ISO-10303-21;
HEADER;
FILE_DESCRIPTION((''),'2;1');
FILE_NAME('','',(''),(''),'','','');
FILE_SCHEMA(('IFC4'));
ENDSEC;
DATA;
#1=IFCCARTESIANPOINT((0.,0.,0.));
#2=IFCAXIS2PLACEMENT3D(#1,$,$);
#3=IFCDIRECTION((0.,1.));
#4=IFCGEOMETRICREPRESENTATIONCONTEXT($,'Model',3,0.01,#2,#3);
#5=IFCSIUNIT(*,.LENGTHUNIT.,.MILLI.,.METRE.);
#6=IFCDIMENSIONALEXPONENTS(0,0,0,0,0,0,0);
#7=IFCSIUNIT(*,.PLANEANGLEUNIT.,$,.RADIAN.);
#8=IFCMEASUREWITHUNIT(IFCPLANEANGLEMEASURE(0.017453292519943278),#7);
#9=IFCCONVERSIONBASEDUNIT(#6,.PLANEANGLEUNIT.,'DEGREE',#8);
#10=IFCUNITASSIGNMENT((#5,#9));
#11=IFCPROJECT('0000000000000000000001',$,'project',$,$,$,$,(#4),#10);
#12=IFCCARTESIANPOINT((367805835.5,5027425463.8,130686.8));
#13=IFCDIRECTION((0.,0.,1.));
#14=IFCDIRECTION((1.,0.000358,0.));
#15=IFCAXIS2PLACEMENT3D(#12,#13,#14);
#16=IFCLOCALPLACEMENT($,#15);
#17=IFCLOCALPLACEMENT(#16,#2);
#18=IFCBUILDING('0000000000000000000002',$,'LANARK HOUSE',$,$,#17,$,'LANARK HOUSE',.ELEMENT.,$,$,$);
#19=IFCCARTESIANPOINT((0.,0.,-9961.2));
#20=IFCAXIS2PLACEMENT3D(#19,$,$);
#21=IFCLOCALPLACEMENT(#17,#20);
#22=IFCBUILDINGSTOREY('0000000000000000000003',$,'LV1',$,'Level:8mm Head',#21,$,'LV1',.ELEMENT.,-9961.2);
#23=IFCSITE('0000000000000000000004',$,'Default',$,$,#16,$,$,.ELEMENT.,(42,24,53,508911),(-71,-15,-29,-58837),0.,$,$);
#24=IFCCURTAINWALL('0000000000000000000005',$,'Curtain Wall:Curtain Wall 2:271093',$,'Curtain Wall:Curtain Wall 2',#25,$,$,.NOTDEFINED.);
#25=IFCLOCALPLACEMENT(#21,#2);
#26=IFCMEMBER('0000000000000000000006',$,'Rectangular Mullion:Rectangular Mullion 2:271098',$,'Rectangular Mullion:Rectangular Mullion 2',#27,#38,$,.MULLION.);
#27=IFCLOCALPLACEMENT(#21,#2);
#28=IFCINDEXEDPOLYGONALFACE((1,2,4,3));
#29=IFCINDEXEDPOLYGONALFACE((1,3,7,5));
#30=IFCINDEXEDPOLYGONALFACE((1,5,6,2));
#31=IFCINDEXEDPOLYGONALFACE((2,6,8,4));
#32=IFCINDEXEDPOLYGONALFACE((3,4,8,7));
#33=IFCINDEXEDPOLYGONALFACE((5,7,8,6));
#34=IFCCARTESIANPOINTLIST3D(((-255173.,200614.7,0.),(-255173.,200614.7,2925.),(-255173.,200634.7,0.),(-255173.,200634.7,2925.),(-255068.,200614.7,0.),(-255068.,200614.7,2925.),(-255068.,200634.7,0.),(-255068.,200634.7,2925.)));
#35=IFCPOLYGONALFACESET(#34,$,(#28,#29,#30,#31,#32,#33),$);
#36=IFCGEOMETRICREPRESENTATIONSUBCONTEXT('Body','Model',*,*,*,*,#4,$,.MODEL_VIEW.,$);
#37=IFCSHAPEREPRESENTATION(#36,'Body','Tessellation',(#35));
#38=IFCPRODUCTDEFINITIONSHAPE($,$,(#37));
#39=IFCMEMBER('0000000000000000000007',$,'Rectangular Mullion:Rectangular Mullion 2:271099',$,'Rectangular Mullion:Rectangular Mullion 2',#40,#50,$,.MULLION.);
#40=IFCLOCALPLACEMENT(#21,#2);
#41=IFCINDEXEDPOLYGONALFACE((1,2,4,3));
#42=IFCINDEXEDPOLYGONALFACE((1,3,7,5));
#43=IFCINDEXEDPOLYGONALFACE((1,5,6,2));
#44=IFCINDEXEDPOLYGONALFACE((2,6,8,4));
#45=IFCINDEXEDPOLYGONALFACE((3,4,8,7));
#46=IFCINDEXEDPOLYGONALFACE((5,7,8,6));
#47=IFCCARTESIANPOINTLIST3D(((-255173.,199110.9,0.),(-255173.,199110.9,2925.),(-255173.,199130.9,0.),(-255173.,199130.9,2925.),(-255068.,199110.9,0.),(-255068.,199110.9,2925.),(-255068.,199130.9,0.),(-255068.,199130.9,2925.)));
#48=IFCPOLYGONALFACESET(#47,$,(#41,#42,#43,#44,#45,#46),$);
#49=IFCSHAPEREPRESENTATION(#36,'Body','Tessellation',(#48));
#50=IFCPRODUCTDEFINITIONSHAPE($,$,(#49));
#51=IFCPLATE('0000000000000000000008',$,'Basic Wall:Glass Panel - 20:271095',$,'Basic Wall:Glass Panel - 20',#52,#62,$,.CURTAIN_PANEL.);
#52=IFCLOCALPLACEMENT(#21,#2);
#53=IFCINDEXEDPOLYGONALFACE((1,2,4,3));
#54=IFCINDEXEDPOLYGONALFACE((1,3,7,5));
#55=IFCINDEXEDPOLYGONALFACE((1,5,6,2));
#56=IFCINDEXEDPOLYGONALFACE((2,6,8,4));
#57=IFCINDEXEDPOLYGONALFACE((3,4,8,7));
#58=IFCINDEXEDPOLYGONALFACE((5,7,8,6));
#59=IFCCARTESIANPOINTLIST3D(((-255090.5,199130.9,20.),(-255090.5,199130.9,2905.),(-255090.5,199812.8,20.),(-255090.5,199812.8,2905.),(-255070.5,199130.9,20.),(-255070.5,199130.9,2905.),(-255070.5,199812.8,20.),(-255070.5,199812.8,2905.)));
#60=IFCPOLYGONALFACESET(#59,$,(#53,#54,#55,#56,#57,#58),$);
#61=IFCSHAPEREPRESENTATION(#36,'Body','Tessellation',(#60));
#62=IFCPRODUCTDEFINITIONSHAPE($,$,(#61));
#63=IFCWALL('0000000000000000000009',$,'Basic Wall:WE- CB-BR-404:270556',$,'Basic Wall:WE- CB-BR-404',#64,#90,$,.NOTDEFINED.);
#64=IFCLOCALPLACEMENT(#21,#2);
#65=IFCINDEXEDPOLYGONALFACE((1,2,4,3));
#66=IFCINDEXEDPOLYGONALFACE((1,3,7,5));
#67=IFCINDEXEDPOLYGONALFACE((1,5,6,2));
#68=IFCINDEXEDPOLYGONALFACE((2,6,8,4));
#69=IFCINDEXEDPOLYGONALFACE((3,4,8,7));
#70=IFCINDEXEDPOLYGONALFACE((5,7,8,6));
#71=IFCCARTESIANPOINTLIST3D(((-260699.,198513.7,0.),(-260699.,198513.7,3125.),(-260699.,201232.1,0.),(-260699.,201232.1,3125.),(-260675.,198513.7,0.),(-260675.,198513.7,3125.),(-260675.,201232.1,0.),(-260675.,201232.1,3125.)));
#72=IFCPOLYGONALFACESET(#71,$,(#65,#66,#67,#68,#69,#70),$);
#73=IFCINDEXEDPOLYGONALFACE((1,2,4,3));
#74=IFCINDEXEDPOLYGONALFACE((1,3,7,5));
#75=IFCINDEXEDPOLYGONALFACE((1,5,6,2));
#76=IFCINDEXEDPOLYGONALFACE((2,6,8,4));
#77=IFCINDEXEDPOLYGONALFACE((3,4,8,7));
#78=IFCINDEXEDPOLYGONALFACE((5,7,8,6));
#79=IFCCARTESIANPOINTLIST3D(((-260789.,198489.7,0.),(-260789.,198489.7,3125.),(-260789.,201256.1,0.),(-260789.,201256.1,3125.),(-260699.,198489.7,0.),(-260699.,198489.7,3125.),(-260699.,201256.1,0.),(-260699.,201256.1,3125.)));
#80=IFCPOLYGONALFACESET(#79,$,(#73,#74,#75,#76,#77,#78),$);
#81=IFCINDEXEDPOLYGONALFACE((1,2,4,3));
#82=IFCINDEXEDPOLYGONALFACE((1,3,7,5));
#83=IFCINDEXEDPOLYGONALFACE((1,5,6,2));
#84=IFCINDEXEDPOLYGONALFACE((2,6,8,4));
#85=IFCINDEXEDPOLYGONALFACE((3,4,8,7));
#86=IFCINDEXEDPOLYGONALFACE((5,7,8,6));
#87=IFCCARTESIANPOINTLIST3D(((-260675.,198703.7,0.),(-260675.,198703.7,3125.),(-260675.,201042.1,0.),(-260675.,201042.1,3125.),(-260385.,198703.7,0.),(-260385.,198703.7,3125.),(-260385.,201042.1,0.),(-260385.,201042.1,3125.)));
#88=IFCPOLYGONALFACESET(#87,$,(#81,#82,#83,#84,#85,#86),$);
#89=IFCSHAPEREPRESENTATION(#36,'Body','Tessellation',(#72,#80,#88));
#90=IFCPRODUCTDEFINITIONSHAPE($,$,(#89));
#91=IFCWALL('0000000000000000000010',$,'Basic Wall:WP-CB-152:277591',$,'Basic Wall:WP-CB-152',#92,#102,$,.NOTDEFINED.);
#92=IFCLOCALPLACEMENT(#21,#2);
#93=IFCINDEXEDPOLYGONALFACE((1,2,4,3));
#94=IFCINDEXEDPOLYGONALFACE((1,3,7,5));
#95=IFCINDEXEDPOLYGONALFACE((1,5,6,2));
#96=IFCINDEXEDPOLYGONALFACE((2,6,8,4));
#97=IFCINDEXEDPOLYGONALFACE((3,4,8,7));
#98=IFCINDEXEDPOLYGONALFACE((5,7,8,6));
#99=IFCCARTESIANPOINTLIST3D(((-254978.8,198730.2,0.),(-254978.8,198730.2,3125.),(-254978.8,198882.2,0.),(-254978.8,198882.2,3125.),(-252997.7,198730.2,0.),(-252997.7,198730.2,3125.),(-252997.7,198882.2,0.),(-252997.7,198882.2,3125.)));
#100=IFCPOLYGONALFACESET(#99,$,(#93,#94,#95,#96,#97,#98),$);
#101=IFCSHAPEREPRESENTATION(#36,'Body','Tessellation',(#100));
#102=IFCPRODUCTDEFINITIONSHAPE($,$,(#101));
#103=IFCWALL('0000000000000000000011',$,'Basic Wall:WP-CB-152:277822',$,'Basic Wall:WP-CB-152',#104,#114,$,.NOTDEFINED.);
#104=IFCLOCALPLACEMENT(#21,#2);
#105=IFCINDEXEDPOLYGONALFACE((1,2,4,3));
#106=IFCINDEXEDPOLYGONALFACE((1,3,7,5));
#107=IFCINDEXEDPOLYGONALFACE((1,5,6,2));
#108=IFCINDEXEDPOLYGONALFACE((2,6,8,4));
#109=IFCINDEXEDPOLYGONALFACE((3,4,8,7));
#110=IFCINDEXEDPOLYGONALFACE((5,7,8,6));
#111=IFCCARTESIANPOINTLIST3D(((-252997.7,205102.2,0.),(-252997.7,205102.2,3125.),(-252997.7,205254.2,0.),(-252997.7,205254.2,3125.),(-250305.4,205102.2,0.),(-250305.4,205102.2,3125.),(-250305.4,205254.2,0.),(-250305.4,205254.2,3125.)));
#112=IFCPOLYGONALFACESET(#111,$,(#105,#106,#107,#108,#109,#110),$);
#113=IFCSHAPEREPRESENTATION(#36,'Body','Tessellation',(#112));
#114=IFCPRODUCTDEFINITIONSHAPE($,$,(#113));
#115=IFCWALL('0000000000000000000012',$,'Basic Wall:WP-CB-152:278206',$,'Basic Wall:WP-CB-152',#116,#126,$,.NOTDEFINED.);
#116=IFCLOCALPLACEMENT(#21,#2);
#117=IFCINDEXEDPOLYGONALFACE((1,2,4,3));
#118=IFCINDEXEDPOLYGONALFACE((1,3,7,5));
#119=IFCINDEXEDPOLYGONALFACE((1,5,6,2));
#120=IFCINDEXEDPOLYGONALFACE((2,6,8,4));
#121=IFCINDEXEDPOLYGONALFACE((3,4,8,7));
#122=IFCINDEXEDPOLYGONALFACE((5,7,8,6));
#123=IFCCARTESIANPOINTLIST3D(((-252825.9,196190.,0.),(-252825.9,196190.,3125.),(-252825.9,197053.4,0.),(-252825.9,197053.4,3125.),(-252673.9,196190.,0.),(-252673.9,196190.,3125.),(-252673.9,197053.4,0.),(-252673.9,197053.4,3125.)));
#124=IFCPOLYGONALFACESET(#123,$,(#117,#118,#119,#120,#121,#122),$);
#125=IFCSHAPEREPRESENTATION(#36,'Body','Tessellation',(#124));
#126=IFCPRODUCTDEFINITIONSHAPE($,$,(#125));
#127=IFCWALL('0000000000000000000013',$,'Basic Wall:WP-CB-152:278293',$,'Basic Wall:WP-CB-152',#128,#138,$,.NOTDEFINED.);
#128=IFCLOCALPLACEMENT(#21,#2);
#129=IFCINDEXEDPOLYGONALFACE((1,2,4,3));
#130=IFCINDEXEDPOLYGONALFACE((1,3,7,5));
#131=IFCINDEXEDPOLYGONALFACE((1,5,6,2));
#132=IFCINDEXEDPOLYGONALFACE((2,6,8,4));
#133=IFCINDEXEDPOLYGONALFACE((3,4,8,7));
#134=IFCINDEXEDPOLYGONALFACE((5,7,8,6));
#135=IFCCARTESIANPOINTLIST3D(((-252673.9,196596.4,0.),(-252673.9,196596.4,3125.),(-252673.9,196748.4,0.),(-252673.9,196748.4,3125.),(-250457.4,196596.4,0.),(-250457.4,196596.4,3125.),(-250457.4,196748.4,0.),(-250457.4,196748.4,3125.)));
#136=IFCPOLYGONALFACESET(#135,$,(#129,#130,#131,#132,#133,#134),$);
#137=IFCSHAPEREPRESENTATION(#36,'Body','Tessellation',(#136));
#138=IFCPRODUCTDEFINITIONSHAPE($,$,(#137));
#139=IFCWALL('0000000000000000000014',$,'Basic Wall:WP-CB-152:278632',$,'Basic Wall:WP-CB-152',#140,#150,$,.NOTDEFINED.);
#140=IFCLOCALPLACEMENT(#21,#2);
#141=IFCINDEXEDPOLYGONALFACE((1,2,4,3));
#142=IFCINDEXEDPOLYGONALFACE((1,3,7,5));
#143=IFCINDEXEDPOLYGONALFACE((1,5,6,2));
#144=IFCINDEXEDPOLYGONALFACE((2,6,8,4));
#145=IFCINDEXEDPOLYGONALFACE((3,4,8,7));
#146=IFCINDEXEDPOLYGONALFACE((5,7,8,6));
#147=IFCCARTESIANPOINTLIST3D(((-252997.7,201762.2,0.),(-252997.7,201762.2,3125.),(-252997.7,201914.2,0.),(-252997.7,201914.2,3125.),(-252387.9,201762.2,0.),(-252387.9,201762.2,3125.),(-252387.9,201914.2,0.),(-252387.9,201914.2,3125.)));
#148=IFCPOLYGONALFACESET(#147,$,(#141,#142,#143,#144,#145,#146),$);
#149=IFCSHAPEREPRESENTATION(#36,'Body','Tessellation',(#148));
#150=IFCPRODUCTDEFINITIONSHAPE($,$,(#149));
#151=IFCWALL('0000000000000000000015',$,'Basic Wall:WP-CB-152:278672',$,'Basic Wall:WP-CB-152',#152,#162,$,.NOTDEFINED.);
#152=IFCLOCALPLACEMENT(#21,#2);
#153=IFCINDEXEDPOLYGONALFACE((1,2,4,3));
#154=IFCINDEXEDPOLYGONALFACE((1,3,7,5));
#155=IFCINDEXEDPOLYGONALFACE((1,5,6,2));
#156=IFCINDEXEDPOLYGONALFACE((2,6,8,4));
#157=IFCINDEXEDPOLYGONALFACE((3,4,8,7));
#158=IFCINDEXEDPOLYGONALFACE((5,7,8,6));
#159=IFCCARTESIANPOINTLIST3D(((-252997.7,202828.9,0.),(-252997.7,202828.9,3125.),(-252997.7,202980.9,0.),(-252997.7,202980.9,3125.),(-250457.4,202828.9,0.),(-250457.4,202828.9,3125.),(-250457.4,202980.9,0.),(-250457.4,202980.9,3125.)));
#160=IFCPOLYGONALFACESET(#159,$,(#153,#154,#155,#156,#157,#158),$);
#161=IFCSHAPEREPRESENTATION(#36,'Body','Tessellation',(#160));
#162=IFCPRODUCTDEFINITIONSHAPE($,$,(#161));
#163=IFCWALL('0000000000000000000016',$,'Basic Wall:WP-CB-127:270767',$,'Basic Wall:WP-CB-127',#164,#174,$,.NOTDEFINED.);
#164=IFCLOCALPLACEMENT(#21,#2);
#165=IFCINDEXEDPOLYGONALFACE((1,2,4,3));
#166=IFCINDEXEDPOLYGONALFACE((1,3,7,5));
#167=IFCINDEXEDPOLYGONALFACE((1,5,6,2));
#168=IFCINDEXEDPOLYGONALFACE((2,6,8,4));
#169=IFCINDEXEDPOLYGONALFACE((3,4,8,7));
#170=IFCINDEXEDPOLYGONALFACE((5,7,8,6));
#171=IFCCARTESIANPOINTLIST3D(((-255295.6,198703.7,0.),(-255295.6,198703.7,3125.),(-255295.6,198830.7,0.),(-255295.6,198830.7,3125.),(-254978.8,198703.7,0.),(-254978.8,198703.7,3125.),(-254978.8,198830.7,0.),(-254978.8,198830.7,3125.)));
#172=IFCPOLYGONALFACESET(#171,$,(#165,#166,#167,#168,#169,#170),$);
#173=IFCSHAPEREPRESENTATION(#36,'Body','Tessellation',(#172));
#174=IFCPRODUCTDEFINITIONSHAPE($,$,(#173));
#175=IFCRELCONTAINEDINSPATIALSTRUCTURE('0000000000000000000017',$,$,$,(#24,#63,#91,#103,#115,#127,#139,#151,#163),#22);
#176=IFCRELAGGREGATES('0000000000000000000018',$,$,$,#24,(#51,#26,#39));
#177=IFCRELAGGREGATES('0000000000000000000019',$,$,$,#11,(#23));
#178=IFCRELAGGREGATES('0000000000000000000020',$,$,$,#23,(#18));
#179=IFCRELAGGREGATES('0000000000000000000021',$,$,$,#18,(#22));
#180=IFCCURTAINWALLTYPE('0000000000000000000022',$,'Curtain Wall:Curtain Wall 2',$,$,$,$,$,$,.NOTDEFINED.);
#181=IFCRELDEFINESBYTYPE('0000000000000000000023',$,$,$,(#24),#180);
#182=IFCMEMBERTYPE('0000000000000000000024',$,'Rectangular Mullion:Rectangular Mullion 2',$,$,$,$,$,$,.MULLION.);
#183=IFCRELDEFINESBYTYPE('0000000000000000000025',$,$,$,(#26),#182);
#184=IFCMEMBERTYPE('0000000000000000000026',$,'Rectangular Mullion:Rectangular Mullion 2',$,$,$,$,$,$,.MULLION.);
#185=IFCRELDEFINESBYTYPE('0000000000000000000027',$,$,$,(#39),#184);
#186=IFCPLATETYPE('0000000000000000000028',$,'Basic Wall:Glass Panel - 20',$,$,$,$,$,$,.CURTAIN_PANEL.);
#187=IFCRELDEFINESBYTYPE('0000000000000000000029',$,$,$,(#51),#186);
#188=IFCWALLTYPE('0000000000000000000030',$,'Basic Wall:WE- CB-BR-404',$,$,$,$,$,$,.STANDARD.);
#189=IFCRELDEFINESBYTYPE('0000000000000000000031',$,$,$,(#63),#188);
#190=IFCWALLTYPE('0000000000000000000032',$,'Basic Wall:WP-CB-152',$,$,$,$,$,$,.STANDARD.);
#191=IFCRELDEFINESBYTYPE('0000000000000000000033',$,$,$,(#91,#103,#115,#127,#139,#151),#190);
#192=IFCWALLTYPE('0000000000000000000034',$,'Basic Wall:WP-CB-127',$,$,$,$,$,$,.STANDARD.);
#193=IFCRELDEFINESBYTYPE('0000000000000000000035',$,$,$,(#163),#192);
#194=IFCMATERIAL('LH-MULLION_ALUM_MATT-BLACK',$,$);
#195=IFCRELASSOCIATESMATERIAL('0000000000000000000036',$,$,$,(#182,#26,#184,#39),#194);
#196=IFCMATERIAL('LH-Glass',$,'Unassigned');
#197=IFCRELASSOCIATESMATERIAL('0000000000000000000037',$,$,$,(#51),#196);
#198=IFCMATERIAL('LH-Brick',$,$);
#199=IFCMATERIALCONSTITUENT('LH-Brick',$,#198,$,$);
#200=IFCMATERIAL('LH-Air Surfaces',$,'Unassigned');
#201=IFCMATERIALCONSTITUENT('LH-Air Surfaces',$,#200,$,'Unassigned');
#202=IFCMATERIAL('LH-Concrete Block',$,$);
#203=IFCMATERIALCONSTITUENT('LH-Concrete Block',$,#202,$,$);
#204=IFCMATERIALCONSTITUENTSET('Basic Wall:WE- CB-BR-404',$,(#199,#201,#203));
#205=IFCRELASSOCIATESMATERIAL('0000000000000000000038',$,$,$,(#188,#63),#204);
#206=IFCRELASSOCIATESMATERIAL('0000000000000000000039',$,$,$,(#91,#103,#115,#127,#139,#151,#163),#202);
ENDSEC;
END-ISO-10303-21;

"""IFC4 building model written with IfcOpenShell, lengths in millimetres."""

from ifc_helpers import new_model, entity, si_unit, converted_unit, direction, frame, origin, place, context, subcontext, project, spatial, indexed_curve, outline, extrude, source, transform, mapped, material, constituent, constituent_set, type_object, type_shapes, element, aggregate, save


model = new_model("IFC4")

# Units and contexts
model_context = context("Model", 3, precision=0.01, world=origin(), true_north=direction((0.0, 1.0)))
body_context = subcontext(model_context, "Body", "Model", "MODEL_VIEW")
ifc_project = project(units=[si_unit("LENGTHUNIT", "METRE", prefix="MILLI"), converted_unit("PLANEANGLEUNIT", "DEGREE", entity("IfcPlaneAngleMeasure", 0.017453292519943278), si_unit("PLANEANGLEUNIT", "RADIAN"), dimensions=[0, 0, 0, 0, 0, 0, 0])], contexts=[model_context])

# Site, building, storey
site_placement = place(None, frame((367805835.5, 5027425463.8, 130686.8), z_axis=(0.0, 0.0, 1.0), x_axis=(1.0, 0.000358, 0.0)))
site = spatial("IfcSite", under=ifc_project, at=site_placement, Name="Default", CompositionType="ELEMENT", RefLatitude=(42, 24, 53, 508911), RefLongitude=(-71, -15, -29, -58837), RefElevation=0.0)
building_placement = place(site_placement, origin())
building = spatial("IfcBuilding", under=site, at=building_placement, Name="LANARK HOUSE", LongName="LANARK HOUSE", CompositionType="ELEMENT")
storey_placement = place(building_placement, frame((0.0, 0.0, -9961.2)))
storey = spatial("IfcBuildingStorey", under=building, at=storey_placement, Name="LV1", ObjectType="Level:8mm Head", LongName="LV1", CompositionType="ELEMENT", Elevation=-9961.2)

# Curtain wall, members
curtain_wall_type = type_object("IfcCurtainWallType", Name="Curtain Wall:Curtain Wall 2", PredefinedType="NOTDEFINED")
curtain_wall_placement = place(storey_placement, frame((0.0, 0.0, 9961.2)))
curtain_wall = element("IfcCurtainWall", 1, at=curtain_wall_placement, inside=storey, type_object=curtain_wall_type, Name="Curtain Wall:Curtain Wall 2:271093", ObjectType="Curtain Wall:Curtain Wall 2", PredefinedType="NOTDEFINED")
ifc_material_1 = material(Name="LH-MULLION_ALUM_MATT-BLACK")
member_type_1 = type_object("IfcMemberType", Name="Rectangular Mullion:Rectangular Mullion 2", PredefinedType="MULLION", material=ifc_material_1)
shared_shape_1 = source(origin(), body_context, "Body", "SweptSolid", [
    extrude(outline(indexed_curve([(-10.0, -52.5), (10.0, -52.5), (10.0, 52.5), (-10.0, 52.5), (-10.0, -52.5)], self_intersect=False)), frame((-10.0, -40.0, -2925.0), z_axis=(0.0, 0.0, 1.0), x_axis=(-1.0, 0.0, 0.0)), (0.0, 0.0, 1.0), 2925.0),
])
type_shapes(member_type_1, [shared_shape_1])
member_1_placement = place(curtain_wall_placement, frame((-255080.5, 200634.7, -9961.2), z_axis=(0.0, 0.0, -1.0), x_axis=(0.0, 1.0, 0.0)))
member_1 = element("IfcMember", 2, at=member_1_placement, type_object=member_type_1, material=ifc_material_1, Name="Rectangular Mullion:Rectangular Mullion 2:271098", ObjectType="Rectangular Mullion:Rectangular Mullion 2", PredefinedType="MULLION", context=body_context, shape_type="MappedRepresentation", body=[
    mapped(shared_shape_1, transform((0.0, 0.0, 0.0), scale=1.0)),
])
member_type_2 = type_object("IfcMemberType", Name="Rectangular Mullion:Rectangular Mullion 2", PredefinedType="MULLION", material=ifc_material_1)
shared_shape_2 = source(origin(), body_context, "Body", "SweptSolid", [
    extrude(outline(indexed_curve([(-10.0, -52.5), (10.0, -52.5), (10.0, 52.5), (-10.0, 52.5), (-10.0, -52.5)], self_intersect=False)), frame((-10.0, -40.0, -2925.0), z_axis=(0.0, 0.0, 1.0), x_axis=(-1.0, 0.0, 0.0)), (0.0, 0.0, 1.0), 2925.0),
])
type_shapes(member_type_2, [shared_shape_2])
member_2_placement = place(curtain_wall_placement, frame((-255080.5, 199110.9, -7036.2), z_axis=(0.0, 0.0, 1.0), x_axis=(0.0, -1.0, 0.0)))
member_2 = element("IfcMember", 3, at=member_2_placement, type_object=member_type_2, material=ifc_material_1, Name="Rectangular Mullion:Rectangular Mullion 2:271099", ObjectType="Rectangular Mullion:Rectangular Mullion 2", PredefinedType="MULLION", context=body_context, shape_type="MappedRepresentation", body=[
    mapped(shared_shape_2, transform((0.0, 0.0, 0.0), scale=1.0)),
])

# Plate
ifc_material_2 = material(Name="LH-Glass", Category="Unassigned")
plate_type = type_object("IfcPlateType", Name="Basic Wall:Glass Panel - 20", PredefinedType="CURTAIN_PANEL")
plate_placement = place(storey_placement, frame((-255080.5, 199130.9, 20.0), z_axis=(0.0, 0.0, 1.0), x_axis=(0.0, 1.0, 0.0)))
plate = element("IfcPlate", 4, at=plate_placement, type_object=plate_type, material=ifc_material_2, Name="Basic Wall:Glass Panel - 20:271095", ObjectType="Basic Wall:Glass Panel - 20", PredefinedType="CURTAIN_PANEL", context=body_context, shape_type="SweptSolid", body=[
    extrude(outline(indexed_curve([(-10.0, -341.0), (10.0, -341.0), (10.0, 341.0), (-10.0, 341.0), (-10.0, -341.0)], self_intersect=False)), frame((341.0, 0.0, 0.0), z_axis=(0.0, 0.0, 1.0), x_axis=(0.0, 1.0, 0.0)), (0.0, 0.0, 1.0), 2885.0),
])

# Shared definitions
ifc_material_3 = material(Name="LH-Brick")
ifc_material_4 = material(Name="LH-Air Surfaces", Category="Unassigned")
ifc_material_5 = material(Name="LH-Concrete Block")

# Walls
ifc_constituent_1 = constituent(ifc_material_3, Name="LH-Brick")
ifc_constituent_2 = constituent(ifc_material_4, Name="LH-Air Surfaces", Category="Unassigned")
ifc_constituent_3 = constituent(ifc_material_5, Name="LH-Concrete Block")
ifc_constituent_set_1 = constituent_set(constituents=[ifc_constituent_1, ifc_constituent_2, ifc_constituent_3], Name="Basic Wall:WE- CB-BR-404")
wall_type_1 = type_object("IfcWallType", Name="Basic Wall:WE- CB-BR-404", PredefinedType="STANDARD", material=ifc_constituent_set_1)
wall_1_placement = place(storey_placement, frame((-260587.0, 198703.7, 0.0), z_axis=(0.0, 0.0, 1.0), x_axis=(0.0, 1.0, 0.0)))
element("IfcWall", 5, at=wall_1_placement, inside=storey, type_object=wall_type_1, material=ifc_constituent_set_1, Name="Basic Wall:WE- CB-BR-404:270556", ObjectType="Basic Wall:WE- CB-BR-404", PredefinedType="NOTDEFINED", context=body_context, shape_type="SweptSolid", body=[
    extrude(outline(indexed_curve([(-1359.2, -12.0), (1359.2, -12.0), (1359.2, 12.0), (-1359.2, 12.0), (-1359.2, -12.0)], self_intersect=False)), frame((1169.2, 100.0, 0.0)), (0.0, 0.0, 1.0), 3125.0),
    extrude(outline(indexed_curve([(-45.0, -1383.2), (45.0, -1383.2), (45.0, 1383.2), (-45.0, 1383.2), (-45.0, -1383.2)], self_intersect=False)), frame((1169.2, 157.0, 0.0), z_axis=(0.0, 0.0, 1.0), x_axis=(0.0, -1.0, 0.0)), (0.0, 0.0, 1.0), 3125.0),
    extrude(outline(indexed_curve([(-145.0, -1169.2), (145.0, -1169.2), (145.0, 1169.2), (-145.0, 1169.2), (-145.0, -1169.2)], self_intersect=False)), frame((1169.2, -57.0, 0.0), z_axis=(0.0, 0.0, 1.0), x_axis=(0.0, 1.0, 0.0)), (0.0, 0.0, 1.0), 3125.0),
])
wall_type_2 = type_object("IfcWallType", Name="Basic Wall:WP-CB-152", PredefinedType="STANDARD")
wall_2_placement = place(storey_placement, frame((-254978.8, 198806.2, 0.0)))
element("IfcWall", 6, at=wall_2_placement, inside=storey, type_object=wall_type_2, material=ifc_material_5, Name="Basic Wall:WP-CB-152:277591", ObjectType="Basic Wall:WP-CB-152", PredefinedType="NOTDEFINED", context=body_context, shape_type="SweptSolid", body=[
    extrude(outline(indexed_curve([(1981.0, 76.0), (0.0, 76.0), (0.0, -76.0), (1981.0, -76.0), (1981.0, 76.0)], self_intersect=False)), origin(), (0.0, 0.0, 1.0), 3125.0),
])
wall_3_placement = place(storey_placement, frame((-252997.7, 205178.2, 0.0)))
element("IfcWall", 7, at=wall_3_placement, inside=storey, type_object=wall_type_2, material=ifc_material_5, Name="Basic Wall:WP-CB-152:277822", ObjectType="Basic Wall:WP-CB-152", PredefinedType="NOTDEFINED", context=body_context, shape_type="SweptSolid", body=[
    extrude(outline(indexed_curve([(2692.4, 76.0), (0.0, 76.0), (0.0, -76.0), (2692.4, -76.0), (2692.4, 76.0)], self_intersect=False)), origin(), (0.0, 0.0, 1.0), 3125.0),
])
wall_4_placement = place(storey_placement, frame((-252749.9, 196190.0, 0.0), z_axis=(0.0, 0.0, 1.0), x_axis=(0.0, 1.0, 0.0)))
element("IfcWall", 8, at=wall_4_placement, inside=storey, type_object=wall_type_2, material=ifc_material_5, Name="Basic Wall:WP-CB-152:278206", ObjectType="Basic Wall:WP-CB-152", PredefinedType="NOTDEFINED", context=body_context, shape_type="SweptSolid", body=[
    extrude(outline(indexed_curve([(863.4, 76.0), (0.0, 76.0), (0.0, -76.0), (863.4, -76.0), (863.4, 76.0)], self_intersect=False)), origin(), (0.0, 0.0, 1.0), 3125.0),
])
wall_5_placement = place(storey_placement, frame((-252673.9, 196672.4, 0.0)))
element("IfcWall", 9, at=wall_5_placement, inside=storey, type_object=wall_type_2, material=ifc_material_5, Name="Basic Wall:WP-CB-152:278293", ObjectType="Basic Wall:WP-CB-152", PredefinedType="NOTDEFINED", context=body_context, shape_type="SweptSolid", body=[
    extrude(outline(indexed_curve([(2216.5, 76.0), (0.0, 76.0), (0.0, -76.0), (2216.5, -76.0), (2216.5, 76.0)], self_intersect=False)), origin(), (0.0, 0.0, 1.0), 3125.0),
])
wall_6_placement = place(storey_placement, frame((-252387.9, 201838.2, 0.0), z_axis=(0.0, 0.0, 1.0), x_axis=(-1.0, 0.0, 0.0)))
element("IfcWall", 10, at=wall_6_placement, inside=storey, type_object=wall_type_2, material=ifc_material_5, Name="Basic Wall:WP-CB-152:278632", ObjectType="Basic Wall:WP-CB-152", PredefinedType="NOTDEFINED", context=body_context, shape_type="SweptSolid", body=[
    extrude(outline(indexed_curve([(609.8, 76.0), (0.0, 76.0), (0.0, -76.0), (609.8, -76.0), (609.8, 76.0)], self_intersect=False)), origin(), (0.0, 0.0, 1.0), 3125.0),
])
wall_7_placement = place(storey_placement, frame((-252997.7, 202904.9, 0.0)))
element("IfcWall", 11, at=wall_7_placement, inside=storey, type_object=wall_type_2, material=ifc_material_5, Name="Basic Wall:WP-CB-152:278672", ObjectType="Basic Wall:WP-CB-152", PredefinedType="NOTDEFINED", context=body_context, shape_type="SweptSolid", body=[
    extrude(outline(indexed_curve([(2540.4, 76.0), (0.0, 76.0), (0.0, -76.0), (2540.4, -76.0), (2540.4, 76.0)], self_intersect=False)), origin(), (0.0, 0.0, 1.0), 3125.0),
])
wall_type_3 = type_object("IfcWallType", Name="Basic Wall:WP-CB-127", PredefinedType="STANDARD")
wall_8_placement = place(storey_placement, frame((-254978.8, 198767.2, 0.0), z_axis=(0.0, 0.0, 1.0), x_axis=(-1.0, 0.0, 0.0)))
element("IfcWall", 12, at=wall_8_placement, inside=storey, type_object=wall_type_3, material=ifc_material_5, Name="Basic Wall:WP-CB-127:270767", ObjectType="Basic Wall:WP-CB-127", PredefinedType="NOTDEFINED", context=body_context, shape_type="SweptSolid", body=[
    extrude(outline(indexed_curve([(316.8, 63.5), (0.0, 63.5), (0.0, -63.5), (316.8, -63.5), (316.8, 63.5)], self_intersect=False)), origin(), (0.0, 0.0, 1.0), 3125.0),
])

aggregate(curtain_wall, [plate, member_1, member_2])

save(model, "model.ifc")
